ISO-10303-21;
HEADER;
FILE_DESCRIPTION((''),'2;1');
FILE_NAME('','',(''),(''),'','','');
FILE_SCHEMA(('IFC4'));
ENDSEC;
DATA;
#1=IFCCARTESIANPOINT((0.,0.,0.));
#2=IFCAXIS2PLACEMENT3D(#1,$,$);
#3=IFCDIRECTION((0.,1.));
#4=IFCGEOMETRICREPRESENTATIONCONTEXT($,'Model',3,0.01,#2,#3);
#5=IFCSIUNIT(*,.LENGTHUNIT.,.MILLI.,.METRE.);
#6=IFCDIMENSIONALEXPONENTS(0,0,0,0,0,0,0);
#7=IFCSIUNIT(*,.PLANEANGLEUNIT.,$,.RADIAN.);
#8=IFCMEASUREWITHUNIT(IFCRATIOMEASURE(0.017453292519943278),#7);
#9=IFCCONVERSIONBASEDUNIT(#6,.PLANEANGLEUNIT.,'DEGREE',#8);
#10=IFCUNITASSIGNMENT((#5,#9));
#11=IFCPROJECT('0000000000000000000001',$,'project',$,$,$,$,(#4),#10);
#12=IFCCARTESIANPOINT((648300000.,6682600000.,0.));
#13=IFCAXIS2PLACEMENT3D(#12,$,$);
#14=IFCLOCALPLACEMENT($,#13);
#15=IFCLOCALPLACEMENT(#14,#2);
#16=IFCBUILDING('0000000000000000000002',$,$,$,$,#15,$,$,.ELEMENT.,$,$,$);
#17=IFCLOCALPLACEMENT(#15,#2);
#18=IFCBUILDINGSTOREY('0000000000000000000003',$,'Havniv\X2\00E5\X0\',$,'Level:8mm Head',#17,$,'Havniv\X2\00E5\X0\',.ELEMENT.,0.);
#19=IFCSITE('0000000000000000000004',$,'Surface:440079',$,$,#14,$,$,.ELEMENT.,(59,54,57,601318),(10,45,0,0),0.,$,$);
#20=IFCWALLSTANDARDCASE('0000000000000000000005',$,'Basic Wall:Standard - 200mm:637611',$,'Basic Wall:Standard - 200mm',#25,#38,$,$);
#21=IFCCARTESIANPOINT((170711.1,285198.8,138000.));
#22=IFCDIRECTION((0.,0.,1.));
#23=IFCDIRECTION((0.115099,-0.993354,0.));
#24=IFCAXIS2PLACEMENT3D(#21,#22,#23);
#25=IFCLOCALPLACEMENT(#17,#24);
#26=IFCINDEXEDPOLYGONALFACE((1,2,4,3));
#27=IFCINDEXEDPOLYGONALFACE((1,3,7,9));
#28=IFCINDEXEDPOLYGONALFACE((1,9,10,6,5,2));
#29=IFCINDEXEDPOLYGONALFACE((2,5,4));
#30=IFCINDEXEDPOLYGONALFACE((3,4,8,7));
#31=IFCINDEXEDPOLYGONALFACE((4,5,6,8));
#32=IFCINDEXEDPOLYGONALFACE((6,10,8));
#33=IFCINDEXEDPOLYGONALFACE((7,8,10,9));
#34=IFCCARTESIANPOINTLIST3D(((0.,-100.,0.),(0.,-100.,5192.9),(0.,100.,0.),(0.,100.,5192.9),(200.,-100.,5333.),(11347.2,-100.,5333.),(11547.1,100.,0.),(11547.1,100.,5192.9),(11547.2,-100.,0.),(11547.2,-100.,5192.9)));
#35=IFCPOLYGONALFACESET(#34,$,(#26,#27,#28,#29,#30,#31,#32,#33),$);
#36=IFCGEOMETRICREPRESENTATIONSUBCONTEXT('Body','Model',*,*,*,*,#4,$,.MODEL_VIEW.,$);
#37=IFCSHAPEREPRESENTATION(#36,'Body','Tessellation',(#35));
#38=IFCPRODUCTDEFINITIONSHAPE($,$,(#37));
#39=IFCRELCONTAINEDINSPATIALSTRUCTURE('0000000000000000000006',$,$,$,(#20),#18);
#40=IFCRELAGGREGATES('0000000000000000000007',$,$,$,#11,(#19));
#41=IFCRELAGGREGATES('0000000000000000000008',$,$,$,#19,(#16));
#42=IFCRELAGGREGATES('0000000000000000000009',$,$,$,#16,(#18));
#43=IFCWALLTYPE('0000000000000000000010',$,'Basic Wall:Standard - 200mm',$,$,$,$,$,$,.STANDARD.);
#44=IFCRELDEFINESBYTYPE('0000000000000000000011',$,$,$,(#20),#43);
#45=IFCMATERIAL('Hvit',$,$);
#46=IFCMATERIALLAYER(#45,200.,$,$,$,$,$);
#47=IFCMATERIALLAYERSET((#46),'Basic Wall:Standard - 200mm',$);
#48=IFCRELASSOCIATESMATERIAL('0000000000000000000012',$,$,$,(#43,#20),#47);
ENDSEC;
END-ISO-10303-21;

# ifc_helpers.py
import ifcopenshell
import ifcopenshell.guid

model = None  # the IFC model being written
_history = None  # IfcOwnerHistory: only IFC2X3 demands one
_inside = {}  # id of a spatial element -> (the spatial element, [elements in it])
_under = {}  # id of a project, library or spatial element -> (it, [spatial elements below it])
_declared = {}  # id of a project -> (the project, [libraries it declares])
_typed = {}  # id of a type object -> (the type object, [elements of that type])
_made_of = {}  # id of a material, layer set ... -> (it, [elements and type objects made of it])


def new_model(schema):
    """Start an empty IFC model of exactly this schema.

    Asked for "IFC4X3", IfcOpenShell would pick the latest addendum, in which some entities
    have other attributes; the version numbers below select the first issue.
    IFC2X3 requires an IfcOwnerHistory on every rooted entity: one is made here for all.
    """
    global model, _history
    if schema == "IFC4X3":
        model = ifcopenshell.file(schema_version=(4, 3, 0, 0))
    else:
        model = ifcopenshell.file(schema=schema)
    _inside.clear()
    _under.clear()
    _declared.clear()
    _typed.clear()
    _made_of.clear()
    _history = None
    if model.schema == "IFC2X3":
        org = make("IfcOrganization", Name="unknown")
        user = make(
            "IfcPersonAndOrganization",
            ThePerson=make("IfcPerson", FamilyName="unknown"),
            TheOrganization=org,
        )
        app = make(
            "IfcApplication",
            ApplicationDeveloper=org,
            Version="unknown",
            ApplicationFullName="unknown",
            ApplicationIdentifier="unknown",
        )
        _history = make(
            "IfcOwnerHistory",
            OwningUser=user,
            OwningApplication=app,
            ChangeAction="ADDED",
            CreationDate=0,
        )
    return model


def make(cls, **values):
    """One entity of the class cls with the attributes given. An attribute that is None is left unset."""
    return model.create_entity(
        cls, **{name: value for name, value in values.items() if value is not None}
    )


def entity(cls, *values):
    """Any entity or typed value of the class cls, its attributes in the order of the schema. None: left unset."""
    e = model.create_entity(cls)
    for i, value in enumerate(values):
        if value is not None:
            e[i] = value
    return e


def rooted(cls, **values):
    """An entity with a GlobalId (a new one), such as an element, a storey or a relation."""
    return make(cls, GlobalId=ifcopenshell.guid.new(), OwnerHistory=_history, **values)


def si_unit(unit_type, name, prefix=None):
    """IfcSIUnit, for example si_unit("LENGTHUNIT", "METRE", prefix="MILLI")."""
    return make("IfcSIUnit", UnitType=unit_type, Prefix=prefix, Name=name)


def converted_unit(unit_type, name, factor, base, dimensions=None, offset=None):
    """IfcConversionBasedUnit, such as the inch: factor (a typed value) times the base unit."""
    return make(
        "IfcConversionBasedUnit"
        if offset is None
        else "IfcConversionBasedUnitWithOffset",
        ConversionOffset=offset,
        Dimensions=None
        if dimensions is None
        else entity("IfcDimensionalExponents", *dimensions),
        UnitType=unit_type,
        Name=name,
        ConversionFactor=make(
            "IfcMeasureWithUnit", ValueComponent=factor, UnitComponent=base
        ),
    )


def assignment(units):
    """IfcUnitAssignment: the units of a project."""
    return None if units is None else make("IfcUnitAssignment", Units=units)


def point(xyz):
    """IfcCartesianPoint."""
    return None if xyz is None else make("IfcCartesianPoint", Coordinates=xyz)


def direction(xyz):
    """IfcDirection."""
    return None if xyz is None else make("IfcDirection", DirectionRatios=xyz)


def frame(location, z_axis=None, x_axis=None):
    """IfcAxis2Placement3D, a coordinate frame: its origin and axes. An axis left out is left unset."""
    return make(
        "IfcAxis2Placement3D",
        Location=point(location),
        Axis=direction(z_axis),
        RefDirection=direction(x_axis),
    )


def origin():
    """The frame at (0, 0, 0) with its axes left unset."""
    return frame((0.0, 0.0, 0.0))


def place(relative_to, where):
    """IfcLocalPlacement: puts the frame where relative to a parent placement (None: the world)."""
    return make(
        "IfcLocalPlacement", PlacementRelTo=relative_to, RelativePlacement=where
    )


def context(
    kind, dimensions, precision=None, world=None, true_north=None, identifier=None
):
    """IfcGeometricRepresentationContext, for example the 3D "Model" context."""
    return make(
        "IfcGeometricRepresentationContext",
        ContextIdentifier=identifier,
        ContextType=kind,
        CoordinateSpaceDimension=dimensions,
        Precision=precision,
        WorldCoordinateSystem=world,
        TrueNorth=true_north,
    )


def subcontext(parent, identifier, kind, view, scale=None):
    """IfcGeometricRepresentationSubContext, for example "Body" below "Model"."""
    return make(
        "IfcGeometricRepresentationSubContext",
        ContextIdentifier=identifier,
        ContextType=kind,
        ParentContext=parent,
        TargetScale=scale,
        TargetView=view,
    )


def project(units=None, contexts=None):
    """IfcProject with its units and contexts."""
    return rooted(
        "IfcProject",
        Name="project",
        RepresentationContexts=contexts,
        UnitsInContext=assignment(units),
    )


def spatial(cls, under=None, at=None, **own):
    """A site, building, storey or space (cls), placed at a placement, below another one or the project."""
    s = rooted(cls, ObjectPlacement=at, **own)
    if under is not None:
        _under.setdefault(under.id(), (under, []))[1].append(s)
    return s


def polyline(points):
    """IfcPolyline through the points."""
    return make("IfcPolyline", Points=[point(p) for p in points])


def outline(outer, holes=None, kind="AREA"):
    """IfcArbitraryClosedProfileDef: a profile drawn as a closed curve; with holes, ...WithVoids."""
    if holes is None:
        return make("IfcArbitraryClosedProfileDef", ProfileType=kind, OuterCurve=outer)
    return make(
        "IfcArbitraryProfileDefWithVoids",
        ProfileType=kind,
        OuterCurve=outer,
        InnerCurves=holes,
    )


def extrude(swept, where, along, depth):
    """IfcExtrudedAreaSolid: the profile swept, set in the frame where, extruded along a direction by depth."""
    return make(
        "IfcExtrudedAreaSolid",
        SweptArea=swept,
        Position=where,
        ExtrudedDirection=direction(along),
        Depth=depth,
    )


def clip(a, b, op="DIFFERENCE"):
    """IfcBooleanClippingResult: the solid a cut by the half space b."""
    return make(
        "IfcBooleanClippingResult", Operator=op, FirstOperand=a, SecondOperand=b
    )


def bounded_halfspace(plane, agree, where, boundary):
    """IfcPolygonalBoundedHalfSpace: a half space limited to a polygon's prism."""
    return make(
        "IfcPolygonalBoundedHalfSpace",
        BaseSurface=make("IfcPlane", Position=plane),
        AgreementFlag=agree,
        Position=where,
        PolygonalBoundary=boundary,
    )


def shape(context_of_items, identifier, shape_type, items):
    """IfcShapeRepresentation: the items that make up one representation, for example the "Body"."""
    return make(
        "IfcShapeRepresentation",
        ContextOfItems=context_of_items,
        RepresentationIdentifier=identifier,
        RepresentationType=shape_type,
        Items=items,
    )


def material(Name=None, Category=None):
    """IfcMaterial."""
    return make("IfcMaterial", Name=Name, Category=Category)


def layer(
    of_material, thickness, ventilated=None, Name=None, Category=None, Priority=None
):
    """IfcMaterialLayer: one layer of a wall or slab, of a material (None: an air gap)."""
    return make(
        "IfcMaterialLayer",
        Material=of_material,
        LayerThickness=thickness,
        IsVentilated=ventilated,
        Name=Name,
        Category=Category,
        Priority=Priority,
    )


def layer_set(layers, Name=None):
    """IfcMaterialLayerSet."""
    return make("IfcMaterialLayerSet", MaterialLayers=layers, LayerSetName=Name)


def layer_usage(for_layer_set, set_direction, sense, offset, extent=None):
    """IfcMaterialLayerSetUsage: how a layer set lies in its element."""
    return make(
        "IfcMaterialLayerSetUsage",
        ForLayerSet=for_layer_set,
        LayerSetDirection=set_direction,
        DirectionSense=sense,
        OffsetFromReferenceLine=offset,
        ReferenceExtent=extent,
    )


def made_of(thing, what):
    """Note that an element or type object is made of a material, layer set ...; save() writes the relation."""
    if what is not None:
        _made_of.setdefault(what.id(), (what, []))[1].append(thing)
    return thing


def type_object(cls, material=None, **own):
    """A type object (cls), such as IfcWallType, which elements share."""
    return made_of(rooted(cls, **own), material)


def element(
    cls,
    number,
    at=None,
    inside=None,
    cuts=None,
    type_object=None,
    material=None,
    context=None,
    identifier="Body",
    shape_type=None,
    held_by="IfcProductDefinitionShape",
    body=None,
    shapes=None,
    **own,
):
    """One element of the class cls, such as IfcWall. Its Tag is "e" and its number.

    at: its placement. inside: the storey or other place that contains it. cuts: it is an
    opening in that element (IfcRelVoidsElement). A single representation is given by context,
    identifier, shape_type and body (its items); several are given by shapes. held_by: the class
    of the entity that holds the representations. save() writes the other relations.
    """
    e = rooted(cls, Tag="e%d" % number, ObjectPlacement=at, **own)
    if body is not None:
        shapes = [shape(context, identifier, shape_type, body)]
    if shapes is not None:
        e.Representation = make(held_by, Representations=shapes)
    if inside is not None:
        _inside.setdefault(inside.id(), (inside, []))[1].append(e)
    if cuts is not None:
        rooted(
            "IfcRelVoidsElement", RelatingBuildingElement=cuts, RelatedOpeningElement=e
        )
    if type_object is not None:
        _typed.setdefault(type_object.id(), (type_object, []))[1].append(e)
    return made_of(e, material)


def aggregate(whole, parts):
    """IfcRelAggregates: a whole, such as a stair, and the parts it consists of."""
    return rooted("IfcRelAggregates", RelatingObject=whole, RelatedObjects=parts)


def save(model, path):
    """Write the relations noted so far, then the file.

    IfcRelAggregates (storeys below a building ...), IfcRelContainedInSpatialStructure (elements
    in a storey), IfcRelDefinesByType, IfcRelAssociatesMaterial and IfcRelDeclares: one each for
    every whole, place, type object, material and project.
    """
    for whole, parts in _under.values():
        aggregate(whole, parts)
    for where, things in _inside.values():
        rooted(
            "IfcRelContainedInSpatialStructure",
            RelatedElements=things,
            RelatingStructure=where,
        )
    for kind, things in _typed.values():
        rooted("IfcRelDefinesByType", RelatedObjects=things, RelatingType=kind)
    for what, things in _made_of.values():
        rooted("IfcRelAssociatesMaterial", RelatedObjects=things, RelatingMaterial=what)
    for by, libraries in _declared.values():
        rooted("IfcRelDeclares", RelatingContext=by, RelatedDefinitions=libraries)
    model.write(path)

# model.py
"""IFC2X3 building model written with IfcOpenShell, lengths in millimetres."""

from ifc_helpers import new_model, entity, si_unit, converted_unit, direction, frame, origin, place, context, subcontext, project, spatial, polyline, outline, extrude, clip, bounded_halfspace, material, layer, layer_set, layer_usage, type_object, element, save


model = new_model("IFC2X3")

# Units and contexts
model_context = context("Model", 3, precision=0.01, world=origin(), true_north=direction((0.0, 1.0)))
body_context = subcontext(model_context, "Body", "Model", "MODEL_VIEW")
ifc_project = project(units=[si_unit("LENGTHUNIT", "METRE", prefix="MILLI"), converted_unit("PLANEANGLEUNIT", "DEGREE", entity("IfcRatioMeasure", 0.017453292519943278), si_unit("PLANEANGLEUNIT", "RADIAN"), dimensions=[0, 0, 0, 0, 0, 0, 0])], contexts=[model_context])

# Site, building, storey
site_placement = place(None, frame((648300000.0, 6682600000.0, 0.0)))
site = spatial("IfcSite", under=ifc_project, at=site_placement, Name="Surface:440079", CompositionType="ELEMENT", RefLatitude=(59, 54, 57, 601318), RefLongitude=(10, 45, 0, 0), RefElevation=0.0)
building_placement = place(site_placement, origin())
building = spatial("IfcBuilding", under=site, at=building_placement, CompositionType="ELEMENT")
storey_placement = place(building_placement, origin())
storey = spatial("IfcBuildingStorey", under=building, at=storey_placement, Name="Havnivå", ObjectType="Level:8mm Head", LongName="Havnivå", CompositionType="ELEMENT", Elevation=0.0)

# Wall
ifc_material_1 = material(Name="Hvit")
ifc_layer_1 = layer(ifc_material_1, 200.0)
ifc_layer_set_1 = layer_set([ifc_layer_1], Name="Basic Wall:Standard - 200mm")
ifc_layer_usage_1 = layer_usage(ifc_layer_set_1, "AXIS2", "NEGATIVE", 100.0)
wall_type_1 = type_object("IfcWallType", Name="Basic Wall:Standard - 200mm", PredefinedType="STANDARD", material=ifc_layer_set_1)
wall_1_placement = place(storey_placement, frame((170711.1, 285198.8, 138000.0), z_axis=(0.0, 0.0, 1.0), x_axis=(0.115099, -0.993354, 0.0)))
element("IfcWallStandardCase", 1, at=wall_1_placement, inside=storey, type_object=wall_type_1, material=ifc_layer_usage_1, Name="Basic Wall:Standard - 200mm:637611", ObjectType="Basic Wall:Standard - 200mm", context=body_context, shape_type="Clipping", body=[
    clip(clip(clip(extrude(outline(polyline([(11547.2, -100.0), (11547.1, 100.0), (7919.5, 100.0), (7719.5, 100.0), (4116.2, 100.0), (3916.2, 100.0), (0.0, 100.0), (0.0, -100.0), (200.0, -100.0), (11347.2, -100.0), (11547.2, -100.0)])), origin(), (0.0, 0.0, 1.0), 5333.0), bounded_halfspace(frame((200.0, -100.0, 5333.0), z_axis=(0.0, 0.573576, 0.819152), x_axis=(-1.0, 0.0, 0.0)), False, frame((200.0, -100.0, 5333.0)), polyline([(0.0, 0.0), (3397671.3, 0.0), (3458595.4, 60960.0), (-60960.0, 60960.0), (0.0, 0.0)]))), bounded_halfspace(frame((11347.2, -100.0, 5333.0), z_axis=(0.573576, 0.000338, 0.819152), x_axis=(-0.000589, 1.0, 0.0)), False, frame((11347.2, -100.0, 5333.0)), polyline([(0.0, 0.0), (60960.0, 0.0), (60924.1, 60960.0), (0.0, 0.0)]))), bounded_halfspace(frame((0.0, -100.0, 5192.9), z_axis=(-0.573576, 0.0, 0.819152), x_axis=(0.0, -1.0, 0.0)), False, frame((0.0, -100.0, 5192.9)), polyline([(0.0, 0.0), (60960.0, 0.0), (0.0, 60960.0), (0.0, 0.0)]))),
])

save(model, "model.ifc")
